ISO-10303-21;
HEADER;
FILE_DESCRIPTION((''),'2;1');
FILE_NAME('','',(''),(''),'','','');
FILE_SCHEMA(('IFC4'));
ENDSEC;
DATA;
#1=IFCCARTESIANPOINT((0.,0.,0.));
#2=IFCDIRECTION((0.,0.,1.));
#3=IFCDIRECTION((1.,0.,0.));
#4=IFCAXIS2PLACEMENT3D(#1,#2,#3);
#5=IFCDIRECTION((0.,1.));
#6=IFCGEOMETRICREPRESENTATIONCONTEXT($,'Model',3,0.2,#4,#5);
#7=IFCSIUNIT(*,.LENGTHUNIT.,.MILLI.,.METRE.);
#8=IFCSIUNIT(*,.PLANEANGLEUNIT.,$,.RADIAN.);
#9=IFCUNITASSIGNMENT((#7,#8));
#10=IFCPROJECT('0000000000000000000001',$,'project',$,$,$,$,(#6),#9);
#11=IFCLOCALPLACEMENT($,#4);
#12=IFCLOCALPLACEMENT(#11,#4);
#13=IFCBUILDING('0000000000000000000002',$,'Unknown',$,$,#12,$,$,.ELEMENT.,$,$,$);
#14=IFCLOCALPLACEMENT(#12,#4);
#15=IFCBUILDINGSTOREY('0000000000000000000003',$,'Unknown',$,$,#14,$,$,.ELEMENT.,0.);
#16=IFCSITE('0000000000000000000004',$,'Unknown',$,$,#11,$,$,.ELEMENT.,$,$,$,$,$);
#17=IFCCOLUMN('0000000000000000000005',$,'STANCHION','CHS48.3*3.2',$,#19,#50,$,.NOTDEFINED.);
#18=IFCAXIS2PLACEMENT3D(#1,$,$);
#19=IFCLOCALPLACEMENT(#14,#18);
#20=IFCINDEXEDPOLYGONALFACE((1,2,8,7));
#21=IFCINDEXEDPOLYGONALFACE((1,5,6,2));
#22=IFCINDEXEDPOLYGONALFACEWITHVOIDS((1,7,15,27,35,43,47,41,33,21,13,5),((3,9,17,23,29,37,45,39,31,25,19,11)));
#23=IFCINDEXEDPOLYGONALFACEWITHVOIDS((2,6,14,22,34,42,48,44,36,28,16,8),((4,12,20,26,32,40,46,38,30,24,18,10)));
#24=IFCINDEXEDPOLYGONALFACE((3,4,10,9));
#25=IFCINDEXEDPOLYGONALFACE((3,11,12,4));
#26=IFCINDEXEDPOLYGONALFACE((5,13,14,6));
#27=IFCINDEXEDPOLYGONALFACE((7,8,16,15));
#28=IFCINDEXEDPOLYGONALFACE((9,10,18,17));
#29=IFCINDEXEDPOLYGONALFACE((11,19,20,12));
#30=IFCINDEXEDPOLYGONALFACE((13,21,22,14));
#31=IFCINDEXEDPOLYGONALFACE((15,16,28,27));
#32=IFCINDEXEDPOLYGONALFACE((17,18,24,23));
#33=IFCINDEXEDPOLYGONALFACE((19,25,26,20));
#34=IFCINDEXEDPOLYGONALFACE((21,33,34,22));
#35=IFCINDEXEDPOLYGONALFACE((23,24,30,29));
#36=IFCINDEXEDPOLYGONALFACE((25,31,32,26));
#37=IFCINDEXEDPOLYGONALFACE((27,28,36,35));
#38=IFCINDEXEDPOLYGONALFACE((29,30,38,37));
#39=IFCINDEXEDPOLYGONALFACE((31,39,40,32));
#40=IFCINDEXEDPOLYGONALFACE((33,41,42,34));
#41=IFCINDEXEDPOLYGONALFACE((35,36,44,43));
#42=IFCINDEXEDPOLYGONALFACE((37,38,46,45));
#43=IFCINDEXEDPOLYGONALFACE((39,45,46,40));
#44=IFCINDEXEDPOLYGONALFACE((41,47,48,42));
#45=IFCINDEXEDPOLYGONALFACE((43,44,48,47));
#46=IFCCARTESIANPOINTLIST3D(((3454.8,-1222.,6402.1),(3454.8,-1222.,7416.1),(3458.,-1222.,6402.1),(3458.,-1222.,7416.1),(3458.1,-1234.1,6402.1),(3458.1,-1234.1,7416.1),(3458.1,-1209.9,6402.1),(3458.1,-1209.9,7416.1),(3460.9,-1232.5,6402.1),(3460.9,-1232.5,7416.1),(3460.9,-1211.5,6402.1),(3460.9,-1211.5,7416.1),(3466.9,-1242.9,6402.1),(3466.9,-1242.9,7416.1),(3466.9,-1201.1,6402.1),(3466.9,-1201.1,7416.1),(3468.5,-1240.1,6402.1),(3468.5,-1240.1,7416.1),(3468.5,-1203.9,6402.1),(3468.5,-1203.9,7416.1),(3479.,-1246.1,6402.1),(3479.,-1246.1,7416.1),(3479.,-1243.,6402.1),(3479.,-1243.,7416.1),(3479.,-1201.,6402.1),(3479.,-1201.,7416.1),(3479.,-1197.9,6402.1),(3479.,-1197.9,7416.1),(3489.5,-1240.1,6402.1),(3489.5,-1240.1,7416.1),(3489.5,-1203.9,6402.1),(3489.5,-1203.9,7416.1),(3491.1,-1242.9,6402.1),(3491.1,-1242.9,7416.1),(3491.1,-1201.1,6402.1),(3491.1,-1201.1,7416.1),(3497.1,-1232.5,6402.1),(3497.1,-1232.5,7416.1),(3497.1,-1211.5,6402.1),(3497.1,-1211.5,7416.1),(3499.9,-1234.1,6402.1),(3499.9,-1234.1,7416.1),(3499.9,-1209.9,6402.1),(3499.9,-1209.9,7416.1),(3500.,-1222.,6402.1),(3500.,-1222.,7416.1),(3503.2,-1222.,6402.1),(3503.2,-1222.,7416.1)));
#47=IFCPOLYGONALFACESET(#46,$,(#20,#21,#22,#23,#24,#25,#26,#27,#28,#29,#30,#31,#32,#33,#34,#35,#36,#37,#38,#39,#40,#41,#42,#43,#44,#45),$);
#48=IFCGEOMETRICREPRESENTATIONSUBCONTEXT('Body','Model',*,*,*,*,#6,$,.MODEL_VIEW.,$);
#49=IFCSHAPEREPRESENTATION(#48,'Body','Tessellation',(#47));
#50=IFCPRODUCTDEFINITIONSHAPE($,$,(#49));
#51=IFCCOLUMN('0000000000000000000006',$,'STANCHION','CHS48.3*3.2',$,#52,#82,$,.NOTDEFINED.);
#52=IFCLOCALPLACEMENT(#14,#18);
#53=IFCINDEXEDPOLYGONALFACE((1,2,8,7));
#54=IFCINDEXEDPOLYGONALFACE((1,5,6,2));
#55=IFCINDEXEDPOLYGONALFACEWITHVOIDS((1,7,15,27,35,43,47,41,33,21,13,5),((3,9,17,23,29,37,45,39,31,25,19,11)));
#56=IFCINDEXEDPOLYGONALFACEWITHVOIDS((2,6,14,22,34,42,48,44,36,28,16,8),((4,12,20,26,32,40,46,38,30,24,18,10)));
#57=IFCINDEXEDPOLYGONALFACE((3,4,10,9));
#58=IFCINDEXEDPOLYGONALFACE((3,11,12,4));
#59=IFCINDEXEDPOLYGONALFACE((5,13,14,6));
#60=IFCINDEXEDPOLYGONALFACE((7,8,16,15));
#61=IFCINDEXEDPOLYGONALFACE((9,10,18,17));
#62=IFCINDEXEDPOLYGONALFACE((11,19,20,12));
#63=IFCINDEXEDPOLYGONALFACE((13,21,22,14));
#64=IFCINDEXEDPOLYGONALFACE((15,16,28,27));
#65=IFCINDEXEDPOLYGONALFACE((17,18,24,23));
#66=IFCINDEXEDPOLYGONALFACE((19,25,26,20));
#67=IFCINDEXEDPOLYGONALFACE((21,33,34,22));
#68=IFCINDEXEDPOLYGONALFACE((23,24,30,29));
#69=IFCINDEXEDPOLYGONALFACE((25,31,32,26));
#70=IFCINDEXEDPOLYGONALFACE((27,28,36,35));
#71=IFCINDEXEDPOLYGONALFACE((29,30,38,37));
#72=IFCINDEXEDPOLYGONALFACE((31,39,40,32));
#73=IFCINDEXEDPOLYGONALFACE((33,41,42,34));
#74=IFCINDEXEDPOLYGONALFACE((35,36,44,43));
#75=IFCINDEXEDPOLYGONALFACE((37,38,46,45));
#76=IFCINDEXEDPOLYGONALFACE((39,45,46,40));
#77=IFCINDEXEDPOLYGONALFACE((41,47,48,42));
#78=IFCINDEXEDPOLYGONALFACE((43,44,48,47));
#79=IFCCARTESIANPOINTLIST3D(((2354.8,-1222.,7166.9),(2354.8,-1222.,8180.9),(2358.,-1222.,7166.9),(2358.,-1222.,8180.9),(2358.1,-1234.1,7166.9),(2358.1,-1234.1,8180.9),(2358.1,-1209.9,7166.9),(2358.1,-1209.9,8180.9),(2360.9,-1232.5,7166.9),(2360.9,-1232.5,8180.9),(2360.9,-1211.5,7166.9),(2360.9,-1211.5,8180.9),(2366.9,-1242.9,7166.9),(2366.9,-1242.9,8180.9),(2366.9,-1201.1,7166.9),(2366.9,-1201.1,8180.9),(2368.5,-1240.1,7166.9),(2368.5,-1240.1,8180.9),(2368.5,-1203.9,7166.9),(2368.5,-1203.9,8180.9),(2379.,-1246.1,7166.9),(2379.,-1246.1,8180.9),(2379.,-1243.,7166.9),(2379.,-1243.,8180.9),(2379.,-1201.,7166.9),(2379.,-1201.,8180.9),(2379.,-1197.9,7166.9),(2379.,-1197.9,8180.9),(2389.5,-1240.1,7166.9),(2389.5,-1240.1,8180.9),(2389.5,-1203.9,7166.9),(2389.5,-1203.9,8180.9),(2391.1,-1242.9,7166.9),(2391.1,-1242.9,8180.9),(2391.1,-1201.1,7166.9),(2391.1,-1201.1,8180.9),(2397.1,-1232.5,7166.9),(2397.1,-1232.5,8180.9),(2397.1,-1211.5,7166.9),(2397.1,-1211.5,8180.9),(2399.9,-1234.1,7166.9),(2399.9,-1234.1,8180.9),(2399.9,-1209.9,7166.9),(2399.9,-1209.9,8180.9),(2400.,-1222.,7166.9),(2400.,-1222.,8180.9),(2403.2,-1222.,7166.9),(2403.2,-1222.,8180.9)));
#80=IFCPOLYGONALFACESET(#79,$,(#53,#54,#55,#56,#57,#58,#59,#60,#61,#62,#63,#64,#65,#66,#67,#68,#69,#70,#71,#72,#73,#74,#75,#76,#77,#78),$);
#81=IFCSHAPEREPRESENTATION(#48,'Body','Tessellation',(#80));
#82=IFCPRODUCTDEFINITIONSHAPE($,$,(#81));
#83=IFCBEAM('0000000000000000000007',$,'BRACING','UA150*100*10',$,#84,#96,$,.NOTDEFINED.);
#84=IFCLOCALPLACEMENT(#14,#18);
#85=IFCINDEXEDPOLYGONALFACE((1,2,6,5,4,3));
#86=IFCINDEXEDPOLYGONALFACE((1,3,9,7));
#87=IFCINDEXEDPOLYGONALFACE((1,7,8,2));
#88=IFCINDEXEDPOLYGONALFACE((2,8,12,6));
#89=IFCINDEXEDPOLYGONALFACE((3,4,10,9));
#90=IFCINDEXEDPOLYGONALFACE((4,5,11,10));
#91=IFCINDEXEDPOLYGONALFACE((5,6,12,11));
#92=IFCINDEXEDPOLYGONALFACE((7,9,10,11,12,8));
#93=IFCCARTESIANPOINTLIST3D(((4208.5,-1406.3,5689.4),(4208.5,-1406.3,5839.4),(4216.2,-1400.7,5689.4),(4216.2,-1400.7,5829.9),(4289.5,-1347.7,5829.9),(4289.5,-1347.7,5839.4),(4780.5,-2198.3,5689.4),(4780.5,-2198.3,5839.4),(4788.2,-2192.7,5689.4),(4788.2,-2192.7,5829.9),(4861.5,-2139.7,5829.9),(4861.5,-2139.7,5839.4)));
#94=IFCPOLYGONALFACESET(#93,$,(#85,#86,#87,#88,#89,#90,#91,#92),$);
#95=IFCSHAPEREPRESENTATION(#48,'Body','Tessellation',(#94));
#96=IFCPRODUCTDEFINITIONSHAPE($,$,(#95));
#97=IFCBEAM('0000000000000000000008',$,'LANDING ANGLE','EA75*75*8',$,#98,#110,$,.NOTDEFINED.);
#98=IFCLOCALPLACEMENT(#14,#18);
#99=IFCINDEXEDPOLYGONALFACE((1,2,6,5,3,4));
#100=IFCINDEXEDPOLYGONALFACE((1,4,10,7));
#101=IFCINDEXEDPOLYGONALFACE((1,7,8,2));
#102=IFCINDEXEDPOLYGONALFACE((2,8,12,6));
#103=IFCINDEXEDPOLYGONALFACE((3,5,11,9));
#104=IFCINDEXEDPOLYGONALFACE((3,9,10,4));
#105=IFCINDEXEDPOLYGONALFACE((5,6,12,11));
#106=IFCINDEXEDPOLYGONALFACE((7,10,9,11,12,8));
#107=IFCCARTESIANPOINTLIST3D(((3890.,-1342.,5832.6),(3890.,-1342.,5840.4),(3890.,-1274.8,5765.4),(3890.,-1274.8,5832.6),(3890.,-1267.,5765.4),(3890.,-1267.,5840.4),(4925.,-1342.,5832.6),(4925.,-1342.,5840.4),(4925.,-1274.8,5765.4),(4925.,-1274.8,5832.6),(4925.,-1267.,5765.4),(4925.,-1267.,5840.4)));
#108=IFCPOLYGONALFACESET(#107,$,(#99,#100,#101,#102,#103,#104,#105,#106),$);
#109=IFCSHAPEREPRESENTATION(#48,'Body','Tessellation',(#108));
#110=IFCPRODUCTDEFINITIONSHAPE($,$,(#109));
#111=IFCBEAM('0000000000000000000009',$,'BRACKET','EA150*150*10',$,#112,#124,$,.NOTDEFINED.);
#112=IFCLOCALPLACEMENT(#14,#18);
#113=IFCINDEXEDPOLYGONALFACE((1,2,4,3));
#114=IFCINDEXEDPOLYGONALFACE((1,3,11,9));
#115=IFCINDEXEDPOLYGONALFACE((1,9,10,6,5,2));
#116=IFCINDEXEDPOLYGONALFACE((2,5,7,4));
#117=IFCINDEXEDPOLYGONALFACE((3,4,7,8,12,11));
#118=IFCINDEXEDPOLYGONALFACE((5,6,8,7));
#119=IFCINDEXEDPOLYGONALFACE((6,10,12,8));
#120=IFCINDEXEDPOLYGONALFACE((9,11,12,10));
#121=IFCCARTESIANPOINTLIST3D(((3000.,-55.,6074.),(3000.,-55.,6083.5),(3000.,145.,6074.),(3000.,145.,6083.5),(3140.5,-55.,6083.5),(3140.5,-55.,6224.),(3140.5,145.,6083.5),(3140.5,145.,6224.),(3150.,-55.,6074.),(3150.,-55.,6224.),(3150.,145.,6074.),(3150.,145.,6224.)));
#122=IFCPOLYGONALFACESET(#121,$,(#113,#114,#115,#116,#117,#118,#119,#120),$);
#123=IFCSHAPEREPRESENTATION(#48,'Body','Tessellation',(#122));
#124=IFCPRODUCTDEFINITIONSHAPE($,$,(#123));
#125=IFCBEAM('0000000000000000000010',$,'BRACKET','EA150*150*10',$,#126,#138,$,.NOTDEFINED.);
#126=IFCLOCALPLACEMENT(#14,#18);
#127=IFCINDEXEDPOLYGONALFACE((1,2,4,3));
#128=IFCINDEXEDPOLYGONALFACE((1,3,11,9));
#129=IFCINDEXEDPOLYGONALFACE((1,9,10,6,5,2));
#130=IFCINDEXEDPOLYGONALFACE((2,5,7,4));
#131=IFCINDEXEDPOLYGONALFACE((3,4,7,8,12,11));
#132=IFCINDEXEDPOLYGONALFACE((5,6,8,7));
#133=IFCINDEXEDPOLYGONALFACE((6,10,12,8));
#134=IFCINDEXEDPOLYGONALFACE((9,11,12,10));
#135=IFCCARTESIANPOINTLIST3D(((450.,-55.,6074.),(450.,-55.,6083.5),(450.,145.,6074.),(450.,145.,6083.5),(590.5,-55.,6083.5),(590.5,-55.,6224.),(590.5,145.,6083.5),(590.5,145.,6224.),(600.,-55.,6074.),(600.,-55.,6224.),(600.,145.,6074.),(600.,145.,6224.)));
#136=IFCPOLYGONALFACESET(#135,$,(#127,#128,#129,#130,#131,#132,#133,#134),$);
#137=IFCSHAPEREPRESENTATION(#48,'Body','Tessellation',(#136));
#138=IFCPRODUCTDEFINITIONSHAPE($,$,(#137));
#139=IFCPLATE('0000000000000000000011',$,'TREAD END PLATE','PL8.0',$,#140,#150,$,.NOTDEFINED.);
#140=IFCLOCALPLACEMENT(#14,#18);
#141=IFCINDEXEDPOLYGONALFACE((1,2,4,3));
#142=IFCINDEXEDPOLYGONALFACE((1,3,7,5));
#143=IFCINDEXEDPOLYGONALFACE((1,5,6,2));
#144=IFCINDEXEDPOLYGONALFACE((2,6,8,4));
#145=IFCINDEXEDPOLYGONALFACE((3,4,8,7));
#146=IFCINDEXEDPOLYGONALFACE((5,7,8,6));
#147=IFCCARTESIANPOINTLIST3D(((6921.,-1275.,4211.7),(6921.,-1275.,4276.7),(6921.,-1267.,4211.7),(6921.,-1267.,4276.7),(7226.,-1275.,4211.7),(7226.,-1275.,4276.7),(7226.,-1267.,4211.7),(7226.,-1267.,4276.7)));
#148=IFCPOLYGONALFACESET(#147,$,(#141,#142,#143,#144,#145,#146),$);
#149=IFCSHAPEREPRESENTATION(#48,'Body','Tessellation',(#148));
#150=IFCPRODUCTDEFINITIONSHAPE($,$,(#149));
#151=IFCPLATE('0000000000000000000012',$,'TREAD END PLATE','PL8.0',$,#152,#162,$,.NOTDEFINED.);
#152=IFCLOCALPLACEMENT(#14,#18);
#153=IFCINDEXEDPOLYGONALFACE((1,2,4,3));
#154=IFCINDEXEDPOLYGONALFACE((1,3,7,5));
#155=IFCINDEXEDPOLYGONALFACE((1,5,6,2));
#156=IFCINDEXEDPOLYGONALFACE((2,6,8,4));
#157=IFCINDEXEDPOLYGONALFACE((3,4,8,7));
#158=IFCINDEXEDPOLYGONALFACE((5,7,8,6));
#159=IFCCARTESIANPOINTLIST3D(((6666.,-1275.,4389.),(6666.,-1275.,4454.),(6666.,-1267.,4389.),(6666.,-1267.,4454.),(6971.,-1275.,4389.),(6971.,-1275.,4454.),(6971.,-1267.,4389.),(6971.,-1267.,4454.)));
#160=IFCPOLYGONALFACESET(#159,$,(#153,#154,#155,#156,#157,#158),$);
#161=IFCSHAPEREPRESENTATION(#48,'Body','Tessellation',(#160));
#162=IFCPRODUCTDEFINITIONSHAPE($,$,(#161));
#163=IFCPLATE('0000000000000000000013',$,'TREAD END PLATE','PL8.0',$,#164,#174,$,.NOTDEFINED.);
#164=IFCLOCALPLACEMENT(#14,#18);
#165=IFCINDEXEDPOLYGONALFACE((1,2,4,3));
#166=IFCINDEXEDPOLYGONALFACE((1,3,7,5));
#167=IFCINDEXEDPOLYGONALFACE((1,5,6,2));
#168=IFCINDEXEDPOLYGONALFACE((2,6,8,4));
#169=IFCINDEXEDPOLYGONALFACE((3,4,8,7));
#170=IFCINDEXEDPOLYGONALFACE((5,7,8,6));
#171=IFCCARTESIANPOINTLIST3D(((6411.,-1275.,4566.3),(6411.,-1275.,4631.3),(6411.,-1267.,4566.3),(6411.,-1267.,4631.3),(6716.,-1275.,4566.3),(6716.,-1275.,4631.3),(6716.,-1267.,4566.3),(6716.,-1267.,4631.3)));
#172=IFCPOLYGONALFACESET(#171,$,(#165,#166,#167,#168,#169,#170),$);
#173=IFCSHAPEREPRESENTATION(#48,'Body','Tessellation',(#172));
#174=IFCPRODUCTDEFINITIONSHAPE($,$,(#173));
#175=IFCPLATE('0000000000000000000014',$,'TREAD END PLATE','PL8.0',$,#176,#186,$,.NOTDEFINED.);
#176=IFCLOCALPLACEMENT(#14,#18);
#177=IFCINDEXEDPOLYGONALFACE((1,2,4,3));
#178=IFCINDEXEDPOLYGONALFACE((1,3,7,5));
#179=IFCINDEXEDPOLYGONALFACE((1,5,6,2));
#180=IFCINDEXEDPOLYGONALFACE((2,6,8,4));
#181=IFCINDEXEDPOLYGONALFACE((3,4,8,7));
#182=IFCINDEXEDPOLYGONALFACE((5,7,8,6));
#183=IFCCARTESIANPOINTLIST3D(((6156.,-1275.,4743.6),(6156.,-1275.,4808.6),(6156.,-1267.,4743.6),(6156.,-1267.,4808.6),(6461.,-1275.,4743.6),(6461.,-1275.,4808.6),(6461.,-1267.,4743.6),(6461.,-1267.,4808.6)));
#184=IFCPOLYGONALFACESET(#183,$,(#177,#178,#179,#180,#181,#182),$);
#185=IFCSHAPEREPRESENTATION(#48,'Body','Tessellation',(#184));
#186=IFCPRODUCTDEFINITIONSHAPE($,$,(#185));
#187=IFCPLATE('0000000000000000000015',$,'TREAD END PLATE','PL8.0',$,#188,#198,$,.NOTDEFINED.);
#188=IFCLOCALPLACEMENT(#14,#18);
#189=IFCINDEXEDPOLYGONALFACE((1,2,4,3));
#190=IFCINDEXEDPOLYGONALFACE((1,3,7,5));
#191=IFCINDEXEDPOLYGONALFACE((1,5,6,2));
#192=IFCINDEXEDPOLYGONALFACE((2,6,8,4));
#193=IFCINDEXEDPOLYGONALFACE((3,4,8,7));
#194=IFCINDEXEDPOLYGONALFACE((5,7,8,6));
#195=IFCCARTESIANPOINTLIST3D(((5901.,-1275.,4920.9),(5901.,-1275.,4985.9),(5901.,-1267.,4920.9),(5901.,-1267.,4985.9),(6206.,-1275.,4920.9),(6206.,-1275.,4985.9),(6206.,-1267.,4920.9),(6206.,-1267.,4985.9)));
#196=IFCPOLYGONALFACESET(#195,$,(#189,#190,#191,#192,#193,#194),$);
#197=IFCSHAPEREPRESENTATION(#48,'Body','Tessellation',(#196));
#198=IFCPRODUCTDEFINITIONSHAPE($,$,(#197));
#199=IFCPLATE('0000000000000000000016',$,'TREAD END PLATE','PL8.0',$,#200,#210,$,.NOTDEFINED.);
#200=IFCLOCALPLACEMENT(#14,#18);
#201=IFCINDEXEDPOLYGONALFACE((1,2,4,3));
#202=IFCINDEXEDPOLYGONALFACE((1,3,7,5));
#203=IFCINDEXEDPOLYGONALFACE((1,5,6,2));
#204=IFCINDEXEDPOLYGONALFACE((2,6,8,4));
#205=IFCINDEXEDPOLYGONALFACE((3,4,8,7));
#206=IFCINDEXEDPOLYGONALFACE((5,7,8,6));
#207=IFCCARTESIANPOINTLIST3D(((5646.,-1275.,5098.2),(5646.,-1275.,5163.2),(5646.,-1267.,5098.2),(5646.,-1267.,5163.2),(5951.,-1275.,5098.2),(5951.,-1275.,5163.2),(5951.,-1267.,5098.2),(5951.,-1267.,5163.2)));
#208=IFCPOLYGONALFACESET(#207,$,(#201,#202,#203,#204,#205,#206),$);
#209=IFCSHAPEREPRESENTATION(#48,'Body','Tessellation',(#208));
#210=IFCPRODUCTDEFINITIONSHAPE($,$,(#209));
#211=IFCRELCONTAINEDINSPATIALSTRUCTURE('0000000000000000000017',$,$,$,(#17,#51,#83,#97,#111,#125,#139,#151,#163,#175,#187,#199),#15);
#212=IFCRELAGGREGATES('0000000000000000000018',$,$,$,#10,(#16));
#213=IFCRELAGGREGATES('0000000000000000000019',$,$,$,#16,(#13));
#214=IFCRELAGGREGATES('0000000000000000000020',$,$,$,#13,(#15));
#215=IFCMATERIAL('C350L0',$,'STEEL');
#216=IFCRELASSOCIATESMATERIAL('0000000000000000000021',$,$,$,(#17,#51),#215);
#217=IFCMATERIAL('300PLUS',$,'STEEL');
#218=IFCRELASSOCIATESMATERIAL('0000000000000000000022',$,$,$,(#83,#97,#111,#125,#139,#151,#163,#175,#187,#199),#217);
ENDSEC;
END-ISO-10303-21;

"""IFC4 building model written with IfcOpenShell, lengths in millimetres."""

from ifc_helpers import new_model, si_unit, direction, frame, origin_with_axes, place, context, subcontext, project, spatial, line, indexed_curve, outline, extrude, material, element, save


model = new_model("IFC4")

# Units and contexts
model_context = context("Model", 3, precision=0.2, world=origin_with_axes(), true_north=direction((0.0, 1.0)))
body_context = subcontext(model_context, "Body", "Model", "MODEL_VIEW")
ifc_project = project(units=[si_unit("LENGTHUNIT", "METRE", prefix="MILLI"), si_unit("PLANEANGLEUNIT", "RADIAN")], contexts=[model_context])

# Site, building, storey
site_placement = place(None, origin_with_axes())
site = spatial("IfcSite", under=ifc_project, at=site_placement, Name="Unknown", CompositionType="ELEMENT")
building_placement = place(site_placement, origin_with_axes())
building = spatial("IfcBuilding", under=site, at=building_placement, Name="Unknown", CompositionType="ELEMENT")
storey_placement = place(building_placement, origin_with_axes())
storey = spatial("IfcBuildingStorey", under=building, at=storey_placement, Name="Unknown", CompositionType="ELEMENT", Elevation=0.0)

# Columns
ifc_material_1 = material(Name="C350L0", Category="STEEL")
for number, where, z_axis, x_axis, name in (
    (1, (3479.0, -1222.0, 6402.1), (-1.0, 0.0, 0.0), (0.0, 0.0, 1.0), "STANCHION"),
    (2, (2379.0, -1222.0, 7166.9), (-1.0, 0.0, 0.0), (0.0, 0.0, 1.0), "STANCHION"),
):
    element("IfcColumn", number, at=place(storey_placement, frame(where, z_axis=z_axis, x_axis=x_axis)), inside=storey, material=ifc_material_1, Name=name, Description="CHS48.3*3.2", PredefinedType="NOTDEFINED", context=body_context, shape_type="SolidModel", body=[
        extrude(outline(indexed_curve([(24.1, 0.0), (20.9, 12.1), (12.1, 20.9), (0.0, 24.1), (-12.1, 20.9), (-20.9, 12.1), (-24.1, 0.0), (-20.9, -12.1), (-12.1, -20.9), (0.0, -24.1), (12.1, -20.9), (20.9, -12.1)], segments=[line(1, 2, 3, 4, 5, 6, 7, 8, 9, 10, 11, 12, 1)]), holes=[indexed_curve([(20.9, 0.0), (18.1, -10.5), (10.5, -18.1), (0.0, -20.9), (-10.5, -18.1), (-18.1, -10.5), (-20.9, 0.0), (-18.1, 10.5), (-10.5, 18.1), (0.0, 20.9), (10.5, 18.1), (18.1, 10.5)], segments=[line(1, 2, 3, 4, 5, 6, 7, 8, 9, 10, 11, 12, 1)])]), frame((0.0, 0.0, 0.0), z_axis=(-1.0, 0.0, 0.0), x_axis=(0.0, 0.0, 1.0)), (0.0, 0.0, -1.0), 1014.0),
    ])

# Beams
ifc_material_2 = material(Name="300PLUS", Category="STEEL")
beam_1_placement = place(storey_placement, frame((4249.0, -1377.0, 5764.4), z_axis=(0.810679, 0.585491, 0.0), x_axis=(0.585491, -0.810679, 0.0)))
element("IfcBeam", 3, at=beam_1_placement, inside=storey, material=ifc_material_2, Name="BRACING", Description="UA150*100*10", PredefinedType="NOTDEFINED", context=body_context, shape_type="SolidModel", body=[
    extrude(outline(indexed_curve([(-50.0, -75.0), (50.0, -75.0), (50.0, -65.5), (-40.5, -65.5), (-40.5, 75.0), (-50.0, 75.0)], segments=[line(1, 2, 3, 4, 5, 6, 1)])), frame((0.0, 0.0, 0.0), z_axis=(-1.0, 0.0, 0.0), x_axis=(0.0, 0.0, 1.0)), (0.0, 0.0, -1.0), 977.0),
])
beam_2_placement = place(storey_placement, frame((3890.0, -1304.5, 5802.9), z_axis=(0.0, 0.0, -1.0), x_axis=(1.0, 0.0, 0.0)))
element("IfcBeam", 4, at=beam_2_placement, inside=storey, material=ifc_material_2, Name="LANDING ANGLE", Description="EA75*75*8", PredefinedType="NOTDEFINED", context=body_context, shape_type="SolidModel", body=[
    extrude(outline(indexed_curve([(-37.5, -37.5), (37.5, -37.5), (37.5, -29.7), (-29.7, -29.7), (-29.7, 37.5), (-37.5, 37.5)], segments=[line(1, 2, 3, 4, 5, 6, 1)])), frame((0.0, 0.0, 0.0), z_axis=(-1.0, 0.0, 0.0), x_axis=(0.0, 0.0, 1.0)), (0.0, 0.0, -1.0), 1035.0),
])
for number, where, z_axis, x_axis, name in (
    (5, (3075.0, -55.0, 6149.0), (0.0, 0.0, 1.0), (0.0, 1.0, 0.0), "BRACKET"),
    (6, (525.0, -55.0, 6149.0), (0.0, 0.0, 1.0), (0.0, 1.0, 0.0), "BRACKET"),
):
    element("IfcBeam", number, at=place(storey_placement, frame(where, z_axis=z_axis, x_axis=x_axis)), inside=storey, material=ifc_material_2, Name=name, Description="EA150*150*10", PredefinedType="NOTDEFINED", context=body_context, shape_type="SolidModel", body=[
        extrude(outline(indexed_curve([(-75.0, -75.0), (75.0, -75.0), (75.0, -65.5), (-65.5, -65.5), (-65.5, 75.0), (-75.0, 75.0)], segments=[line(1, 2, 3, 4, 5, 6, 1)])), frame((0.0, 0.0, 0.0), z_axis=(-1.0, 0.0, 0.0), x_axis=(0.0, 0.0, 1.0)), (0.0, 0.0, -1.0), 200.0),
    ])

# Plates
for number, where, z_axis, x_axis, name in (
    (7, (6921.0, -1271.0, 4211.7), (0.0, -1.0, 0.0), (1.0, 0.0, 0.0), "TREAD END PLATE"),
    (8, (6666.0, -1271.0, 4389.0), (0.0, -1.0, 0.0), (1.0, 0.0, 0.0), "TREAD END PLATE"),
    (9, (6411.0, -1271.0, 4566.3), (0.0, -1.0, 0.0), (1.0, 0.0, 0.0), "TREAD END PLATE"),
    (10, (6156.0, -1271.0, 4743.6), (0.0, -1.0, 0.0), (1.0, 0.0, 0.0), "TREAD END PLATE"),
    (11, (5901.0, -1271.0, 4920.9), (0.0, -1.0, 0.0), (1.0, 0.0, 0.0), "TREAD END PLATE"),
    (12, (5646.0, -1271.0, 5098.2), (0.0, -1.0, 0.0), (1.0, 0.0, 0.0), "TREAD END PLATE"),
):
    element("IfcPlate", number, at=place(storey_placement, frame(where, z_axis=z_axis, x_axis=x_axis)), inside=storey, material=ifc_material_2, Name=name, Description="PL8.0", PredefinedType="NOTDEFINED", context=body_context, shape_type="SolidModel", body=[
        extrude(outline(indexed_curve([(0.0, 0.0), (305.0, 0.0), (305.0, 65.0), (0.0, 65.0)], segments=[line(1, 2, 3, 4, 1)])), frame((0.0, 0.0, 4.0), z_axis=(0.0, 0.0, 1.0), x_axis=(1.0, 0.0, 0.0)), (0.0, 0.0, -1.0), 8.0),
    ])

save(model, "model.ifc")
